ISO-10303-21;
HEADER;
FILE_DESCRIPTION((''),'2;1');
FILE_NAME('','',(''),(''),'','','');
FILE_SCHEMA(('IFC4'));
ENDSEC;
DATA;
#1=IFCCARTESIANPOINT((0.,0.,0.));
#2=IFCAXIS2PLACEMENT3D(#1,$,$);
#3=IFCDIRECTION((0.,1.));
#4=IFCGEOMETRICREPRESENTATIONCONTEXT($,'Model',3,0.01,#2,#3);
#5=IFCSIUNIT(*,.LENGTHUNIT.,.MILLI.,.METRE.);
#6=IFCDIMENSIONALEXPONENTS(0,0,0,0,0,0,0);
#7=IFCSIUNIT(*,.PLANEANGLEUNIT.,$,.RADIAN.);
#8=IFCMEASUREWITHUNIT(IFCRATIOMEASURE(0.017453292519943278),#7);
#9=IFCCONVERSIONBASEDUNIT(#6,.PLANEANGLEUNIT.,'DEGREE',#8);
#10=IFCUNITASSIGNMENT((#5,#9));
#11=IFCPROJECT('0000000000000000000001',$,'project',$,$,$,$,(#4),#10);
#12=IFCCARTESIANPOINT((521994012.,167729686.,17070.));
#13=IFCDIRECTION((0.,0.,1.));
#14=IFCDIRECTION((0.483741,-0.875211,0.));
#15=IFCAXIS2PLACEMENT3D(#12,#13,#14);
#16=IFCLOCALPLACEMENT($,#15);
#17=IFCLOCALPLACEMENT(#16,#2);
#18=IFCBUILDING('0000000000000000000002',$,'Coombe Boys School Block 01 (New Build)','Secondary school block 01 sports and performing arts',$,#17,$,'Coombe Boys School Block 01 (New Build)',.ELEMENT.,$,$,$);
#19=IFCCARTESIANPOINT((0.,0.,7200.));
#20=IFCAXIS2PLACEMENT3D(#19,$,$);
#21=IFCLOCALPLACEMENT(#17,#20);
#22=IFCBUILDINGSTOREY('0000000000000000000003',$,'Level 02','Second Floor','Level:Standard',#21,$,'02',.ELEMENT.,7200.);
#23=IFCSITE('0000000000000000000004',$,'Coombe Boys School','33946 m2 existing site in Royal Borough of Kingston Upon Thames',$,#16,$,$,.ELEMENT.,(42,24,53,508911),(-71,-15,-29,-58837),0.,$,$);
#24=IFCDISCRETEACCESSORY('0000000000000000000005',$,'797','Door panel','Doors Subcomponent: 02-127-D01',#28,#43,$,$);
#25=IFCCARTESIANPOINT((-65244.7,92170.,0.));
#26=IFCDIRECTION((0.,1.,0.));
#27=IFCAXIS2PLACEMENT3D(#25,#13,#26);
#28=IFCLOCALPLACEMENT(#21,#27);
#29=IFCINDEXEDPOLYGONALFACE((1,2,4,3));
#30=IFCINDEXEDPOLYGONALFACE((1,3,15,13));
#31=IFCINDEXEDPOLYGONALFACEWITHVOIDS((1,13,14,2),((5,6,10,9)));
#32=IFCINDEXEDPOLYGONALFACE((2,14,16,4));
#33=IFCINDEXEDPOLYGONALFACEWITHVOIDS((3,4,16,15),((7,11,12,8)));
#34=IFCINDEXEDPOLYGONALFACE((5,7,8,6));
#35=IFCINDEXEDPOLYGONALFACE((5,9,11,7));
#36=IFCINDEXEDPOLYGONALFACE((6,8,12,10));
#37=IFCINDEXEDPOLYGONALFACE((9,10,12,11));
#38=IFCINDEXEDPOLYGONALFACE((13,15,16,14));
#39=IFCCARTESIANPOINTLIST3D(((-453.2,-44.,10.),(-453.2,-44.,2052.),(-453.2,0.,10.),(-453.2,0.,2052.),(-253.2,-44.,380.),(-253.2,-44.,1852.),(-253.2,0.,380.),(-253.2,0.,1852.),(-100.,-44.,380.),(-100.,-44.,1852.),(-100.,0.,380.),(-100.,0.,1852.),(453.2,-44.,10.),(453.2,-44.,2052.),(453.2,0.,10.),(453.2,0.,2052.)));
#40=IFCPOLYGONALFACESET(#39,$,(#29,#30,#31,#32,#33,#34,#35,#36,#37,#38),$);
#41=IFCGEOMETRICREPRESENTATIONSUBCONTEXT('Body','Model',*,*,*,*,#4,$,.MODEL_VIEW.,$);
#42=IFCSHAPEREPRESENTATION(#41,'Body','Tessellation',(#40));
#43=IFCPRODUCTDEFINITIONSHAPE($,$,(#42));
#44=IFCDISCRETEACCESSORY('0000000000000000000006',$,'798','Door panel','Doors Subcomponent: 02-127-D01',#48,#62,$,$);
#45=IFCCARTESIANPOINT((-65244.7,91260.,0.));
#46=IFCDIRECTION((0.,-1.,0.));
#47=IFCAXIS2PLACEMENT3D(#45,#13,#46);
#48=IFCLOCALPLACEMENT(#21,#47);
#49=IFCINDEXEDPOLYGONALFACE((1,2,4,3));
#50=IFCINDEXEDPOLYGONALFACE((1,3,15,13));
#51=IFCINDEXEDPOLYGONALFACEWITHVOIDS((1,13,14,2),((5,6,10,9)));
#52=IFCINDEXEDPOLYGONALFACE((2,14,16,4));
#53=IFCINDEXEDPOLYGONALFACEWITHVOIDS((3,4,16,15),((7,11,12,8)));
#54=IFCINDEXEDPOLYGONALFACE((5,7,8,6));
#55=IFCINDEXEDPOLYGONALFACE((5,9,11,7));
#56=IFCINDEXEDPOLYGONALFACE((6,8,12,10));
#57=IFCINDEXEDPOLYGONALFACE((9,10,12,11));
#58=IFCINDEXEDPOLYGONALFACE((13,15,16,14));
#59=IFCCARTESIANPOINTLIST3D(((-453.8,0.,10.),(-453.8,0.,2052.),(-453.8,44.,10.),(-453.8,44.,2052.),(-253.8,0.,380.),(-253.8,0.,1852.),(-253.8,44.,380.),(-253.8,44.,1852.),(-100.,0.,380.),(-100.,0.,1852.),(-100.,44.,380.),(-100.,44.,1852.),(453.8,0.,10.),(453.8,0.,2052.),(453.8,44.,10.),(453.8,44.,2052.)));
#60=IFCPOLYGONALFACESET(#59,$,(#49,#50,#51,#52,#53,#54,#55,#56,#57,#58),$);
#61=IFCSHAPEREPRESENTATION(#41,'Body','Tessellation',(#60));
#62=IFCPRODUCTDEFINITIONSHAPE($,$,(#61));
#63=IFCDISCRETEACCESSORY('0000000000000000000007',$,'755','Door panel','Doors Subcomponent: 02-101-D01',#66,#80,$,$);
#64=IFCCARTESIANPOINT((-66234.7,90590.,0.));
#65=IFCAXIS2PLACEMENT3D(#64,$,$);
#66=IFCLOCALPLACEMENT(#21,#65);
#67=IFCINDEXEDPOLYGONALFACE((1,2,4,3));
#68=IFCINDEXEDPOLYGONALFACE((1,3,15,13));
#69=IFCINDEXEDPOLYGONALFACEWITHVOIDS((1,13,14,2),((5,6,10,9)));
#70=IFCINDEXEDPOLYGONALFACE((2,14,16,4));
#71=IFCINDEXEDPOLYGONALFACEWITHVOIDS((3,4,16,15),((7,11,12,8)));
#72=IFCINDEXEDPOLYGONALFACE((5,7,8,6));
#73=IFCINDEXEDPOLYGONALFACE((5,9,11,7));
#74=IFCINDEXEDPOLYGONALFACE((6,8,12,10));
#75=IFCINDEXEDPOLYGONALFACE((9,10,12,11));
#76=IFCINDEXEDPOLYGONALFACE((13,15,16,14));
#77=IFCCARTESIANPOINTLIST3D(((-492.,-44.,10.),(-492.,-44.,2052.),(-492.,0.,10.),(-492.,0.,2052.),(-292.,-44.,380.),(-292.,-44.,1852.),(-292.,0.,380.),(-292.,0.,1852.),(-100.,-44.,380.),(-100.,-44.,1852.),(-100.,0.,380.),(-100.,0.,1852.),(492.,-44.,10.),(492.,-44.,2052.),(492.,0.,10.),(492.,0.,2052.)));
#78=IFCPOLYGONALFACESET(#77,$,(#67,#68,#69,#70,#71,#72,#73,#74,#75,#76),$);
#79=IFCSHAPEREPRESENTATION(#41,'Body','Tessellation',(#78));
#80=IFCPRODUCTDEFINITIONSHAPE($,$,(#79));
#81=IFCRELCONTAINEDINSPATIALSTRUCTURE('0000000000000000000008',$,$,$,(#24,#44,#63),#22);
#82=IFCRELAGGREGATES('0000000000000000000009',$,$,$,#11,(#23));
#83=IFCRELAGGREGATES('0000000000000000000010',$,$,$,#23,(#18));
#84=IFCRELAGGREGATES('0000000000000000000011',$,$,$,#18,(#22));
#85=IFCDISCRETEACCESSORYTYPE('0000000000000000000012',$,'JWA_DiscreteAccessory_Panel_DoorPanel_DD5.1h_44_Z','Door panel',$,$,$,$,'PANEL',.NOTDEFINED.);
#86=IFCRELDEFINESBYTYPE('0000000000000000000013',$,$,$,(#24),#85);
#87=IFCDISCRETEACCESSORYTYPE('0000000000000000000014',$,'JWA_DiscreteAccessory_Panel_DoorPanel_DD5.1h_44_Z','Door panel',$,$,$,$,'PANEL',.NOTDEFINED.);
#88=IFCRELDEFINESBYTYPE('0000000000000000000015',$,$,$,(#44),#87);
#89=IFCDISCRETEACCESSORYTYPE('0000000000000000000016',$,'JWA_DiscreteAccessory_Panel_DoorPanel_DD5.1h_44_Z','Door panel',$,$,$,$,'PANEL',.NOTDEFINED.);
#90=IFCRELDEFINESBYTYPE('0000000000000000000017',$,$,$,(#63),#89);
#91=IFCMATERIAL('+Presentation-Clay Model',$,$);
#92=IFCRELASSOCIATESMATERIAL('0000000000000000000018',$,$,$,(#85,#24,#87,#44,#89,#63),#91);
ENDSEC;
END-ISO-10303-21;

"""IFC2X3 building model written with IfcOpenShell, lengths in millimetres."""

from ifc_helpers import new_model, entity, si_unit, converted_unit, direction, frame, origin, place, context, subcontext, project, spatial, polyline, outline, extrude, source, transform, mapped, material, type_object, type_shapes, element, save


model = new_model("IFC2X3")

# Units and contexts
model_context = context("Model", 3, precision=0.01, world=origin(), true_north=direction((0.0, 1.0)))
body_context = subcontext(model_context, "Body", "Model", "MODEL_VIEW")
ifc_project = project(units=[si_unit("LENGTHUNIT", "METRE", prefix="MILLI"), converted_unit("PLANEANGLEUNIT", "DEGREE", entity("IfcRatioMeasure", 0.017453292519943278), si_unit("PLANEANGLEUNIT", "RADIAN"), dimensions=[0, 0, 0, 0, 0, 0, 0])], contexts=[model_context])

# Site, building, storey
site_placement = place(None, frame((521994012.0, 167729686.0, 17070.0), z_axis=(0.0, 0.0, 1.0), x_axis=(0.483741, -0.875211, 0.0)))
site = spatial("IfcSite", under=ifc_project, at=site_placement, Name="Coombe Boys School", Description="33946 m2 existing site in Royal Borough of Kingston Upon Thames", CompositionType="ELEMENT", RefLatitude=(42, 24, 53, 508911), RefLongitude=(-71, -15, -29, -58837), RefElevation=0.0)
building_placement = place(site_placement, origin())
building = spatial("IfcBuilding", under=site, at=building_placement, Name="Coombe Boys School Block 01 (New Build)", Description="Secondary school block 01 sports and performing arts", LongName="Coombe Boys School Block 01 (New Build)", CompositionType="ELEMENT")
storey_placement = place(building_placement, frame((0.0, 0.0, 7200.0)))
storey = spatial("IfcBuildingStorey", under=building, at=storey_placement, Name="Level 02", Description="Second Floor", ObjectType="Level:Standard", LongName="02", CompositionType="ELEMENT", Elevation=7200.0)

# Discrete accessories
ifc_material_1 = material(Name="+Presentation-Clay Model")
discrete_accessory_type_1 = type_object("IfcDiscreteAccessoryType", Name="JWA_DiscreteAccessory_Panel_DoorPanel_DD5.1h_44_Z", Description="Door panel", ElementType="PANEL", material=ifc_material_1)
shared_shape_1 = source(origin(), body_context, "Body", "SweptSolid", [
    extrude(outline(polyline([(-1021.0, -453.3), (1021.0, -453.3), (1021.0, 453.3), (-1021.0, 453.3), (-1021.0, -453.3)]), holes=[polyline([(-821.0, 100.0), (-821.0, 253.2), (651.0, 253.2), (651.0, 100.0), (-821.0, 100.0)])]), frame((0.0, -44.0, 1031.0), z_axis=(0.0, 1.0, 0.0), x_axis=(0.0, 0.0, -1.0)), (0.0, 0.0, 1.0), 44.0),
])
type_shapes(discrete_accessory_type_1, [shared_shape_1])
discrete_accessory_1_placement = place(storey_placement, frame((-65244.7, 92170.0, 0.0), z_axis=(0.0, 0.0, 1.0), x_axis=(0.0, 1.0, 0.0)))
element("IfcDiscreteAccessory", 1, at=discrete_accessory_1_placement, inside=storey, type_object=discrete_accessory_type_1, material=ifc_material_1, Name="797", Description="Door panel", ObjectType="Doors Subcomponent: 02-127-D01", context=body_context, shape_type="MappedRepresentation", body=[
    mapped(shared_shape_1, transform((0.0, 0.0, 0.0), scale=1.0)),
])
discrete_accessory_type_2 = type_object("IfcDiscreteAccessoryType", Name="JWA_DiscreteAccessory_Panel_DoorPanel_DD5.1h_44_Z", Description="Door panel", ElementType="PANEL", material=ifc_material_1)
shared_shape_2 = source(origin(), body_context, "Body", "SweptSolid", [
    extrude(outline(polyline([(-1021.0, -453.7), (1021.0, -453.7), (1021.0, 453.7), (-1021.0, 453.7), (-1021.0, -453.7)]), holes=[polyline([(-821.0, 100.0), (-821.0, 253.7), (651.0, 253.7), (651.0, 100.0), (-821.0, 100.0)])]), frame((0.0, 0.0, 1031.0), z_axis=(0.0, 1.0, 0.0), x_axis=(0.0, 0.0, -1.0)), (0.0, 0.0, 1.0), 44.0),
])
type_shapes(discrete_accessory_type_2, [shared_shape_2])
discrete_accessory_2_placement = place(storey_placement, frame((-65244.7, 91260.0, 0.0), z_axis=(0.0, 0.0, 1.0), x_axis=(0.0, -1.0, 0.0)))
element("IfcDiscreteAccessory", 2, at=discrete_accessory_2_placement, inside=storey, type_object=discrete_accessory_type_2, material=ifc_material_1, Name="798", Description="Door panel", ObjectType="Doors Subcomponent: 02-127-D01", context=body_context, shape_type="MappedRepresentation", body=[
    mapped(shared_shape_2, transform((0.0, 0.0, 0.0), scale=1.0)),
])

# Discrete accessory
discrete_accessory_type_3 = type_object("IfcDiscreteAccessoryType", Name="JWA_DiscreteAccessory_Panel_DoorPanel_DD5.1h_44_Z", Description="Door panel", ElementType="PANEL", material=ifc_material_1)
shared_shape_3 = source(origin(), body_context, "Body", "SweptSolid", [
    extrude(outline(polyline([(-1021.0, -492.0), (1021.0, -492.0), (1021.0, 492.0), (-1021.0, 492.0), (-1021.0, -492.0)]), holes=[polyline([(-821.0, 100.0), (-821.0, 292.0), (651.0, 292.0), (651.0, 100.0), (-821.0, 100.0)])]), frame((0.0, -44.0, 1031.0), z_axis=(0.0, 1.0, 0.0), x_axis=(0.0, 0.0, -1.0)), (0.0, 0.0, 1.0), 44.0),
])
type_shapes(discrete_accessory_type_3, [shared_shape_3])
discrete_accessory_3_placement = place(storey_placement, frame((-66234.7, 90590.0, 0.0)))
element("IfcDiscreteAccessory", 3, at=discrete_accessory_3_placement, inside=storey, type_object=discrete_accessory_type_3, material=ifc_material_1, Name="755", Description="Door panel", ObjectType="Doors Subcomponent: 02-101-D01", context=body_context, shape_type="MappedRepresentation", body=[
    mapped(shared_shape_3, transform((0.0, 0.0, 0.0), scale=1.0)),
])

save(model, "model.ifc")
